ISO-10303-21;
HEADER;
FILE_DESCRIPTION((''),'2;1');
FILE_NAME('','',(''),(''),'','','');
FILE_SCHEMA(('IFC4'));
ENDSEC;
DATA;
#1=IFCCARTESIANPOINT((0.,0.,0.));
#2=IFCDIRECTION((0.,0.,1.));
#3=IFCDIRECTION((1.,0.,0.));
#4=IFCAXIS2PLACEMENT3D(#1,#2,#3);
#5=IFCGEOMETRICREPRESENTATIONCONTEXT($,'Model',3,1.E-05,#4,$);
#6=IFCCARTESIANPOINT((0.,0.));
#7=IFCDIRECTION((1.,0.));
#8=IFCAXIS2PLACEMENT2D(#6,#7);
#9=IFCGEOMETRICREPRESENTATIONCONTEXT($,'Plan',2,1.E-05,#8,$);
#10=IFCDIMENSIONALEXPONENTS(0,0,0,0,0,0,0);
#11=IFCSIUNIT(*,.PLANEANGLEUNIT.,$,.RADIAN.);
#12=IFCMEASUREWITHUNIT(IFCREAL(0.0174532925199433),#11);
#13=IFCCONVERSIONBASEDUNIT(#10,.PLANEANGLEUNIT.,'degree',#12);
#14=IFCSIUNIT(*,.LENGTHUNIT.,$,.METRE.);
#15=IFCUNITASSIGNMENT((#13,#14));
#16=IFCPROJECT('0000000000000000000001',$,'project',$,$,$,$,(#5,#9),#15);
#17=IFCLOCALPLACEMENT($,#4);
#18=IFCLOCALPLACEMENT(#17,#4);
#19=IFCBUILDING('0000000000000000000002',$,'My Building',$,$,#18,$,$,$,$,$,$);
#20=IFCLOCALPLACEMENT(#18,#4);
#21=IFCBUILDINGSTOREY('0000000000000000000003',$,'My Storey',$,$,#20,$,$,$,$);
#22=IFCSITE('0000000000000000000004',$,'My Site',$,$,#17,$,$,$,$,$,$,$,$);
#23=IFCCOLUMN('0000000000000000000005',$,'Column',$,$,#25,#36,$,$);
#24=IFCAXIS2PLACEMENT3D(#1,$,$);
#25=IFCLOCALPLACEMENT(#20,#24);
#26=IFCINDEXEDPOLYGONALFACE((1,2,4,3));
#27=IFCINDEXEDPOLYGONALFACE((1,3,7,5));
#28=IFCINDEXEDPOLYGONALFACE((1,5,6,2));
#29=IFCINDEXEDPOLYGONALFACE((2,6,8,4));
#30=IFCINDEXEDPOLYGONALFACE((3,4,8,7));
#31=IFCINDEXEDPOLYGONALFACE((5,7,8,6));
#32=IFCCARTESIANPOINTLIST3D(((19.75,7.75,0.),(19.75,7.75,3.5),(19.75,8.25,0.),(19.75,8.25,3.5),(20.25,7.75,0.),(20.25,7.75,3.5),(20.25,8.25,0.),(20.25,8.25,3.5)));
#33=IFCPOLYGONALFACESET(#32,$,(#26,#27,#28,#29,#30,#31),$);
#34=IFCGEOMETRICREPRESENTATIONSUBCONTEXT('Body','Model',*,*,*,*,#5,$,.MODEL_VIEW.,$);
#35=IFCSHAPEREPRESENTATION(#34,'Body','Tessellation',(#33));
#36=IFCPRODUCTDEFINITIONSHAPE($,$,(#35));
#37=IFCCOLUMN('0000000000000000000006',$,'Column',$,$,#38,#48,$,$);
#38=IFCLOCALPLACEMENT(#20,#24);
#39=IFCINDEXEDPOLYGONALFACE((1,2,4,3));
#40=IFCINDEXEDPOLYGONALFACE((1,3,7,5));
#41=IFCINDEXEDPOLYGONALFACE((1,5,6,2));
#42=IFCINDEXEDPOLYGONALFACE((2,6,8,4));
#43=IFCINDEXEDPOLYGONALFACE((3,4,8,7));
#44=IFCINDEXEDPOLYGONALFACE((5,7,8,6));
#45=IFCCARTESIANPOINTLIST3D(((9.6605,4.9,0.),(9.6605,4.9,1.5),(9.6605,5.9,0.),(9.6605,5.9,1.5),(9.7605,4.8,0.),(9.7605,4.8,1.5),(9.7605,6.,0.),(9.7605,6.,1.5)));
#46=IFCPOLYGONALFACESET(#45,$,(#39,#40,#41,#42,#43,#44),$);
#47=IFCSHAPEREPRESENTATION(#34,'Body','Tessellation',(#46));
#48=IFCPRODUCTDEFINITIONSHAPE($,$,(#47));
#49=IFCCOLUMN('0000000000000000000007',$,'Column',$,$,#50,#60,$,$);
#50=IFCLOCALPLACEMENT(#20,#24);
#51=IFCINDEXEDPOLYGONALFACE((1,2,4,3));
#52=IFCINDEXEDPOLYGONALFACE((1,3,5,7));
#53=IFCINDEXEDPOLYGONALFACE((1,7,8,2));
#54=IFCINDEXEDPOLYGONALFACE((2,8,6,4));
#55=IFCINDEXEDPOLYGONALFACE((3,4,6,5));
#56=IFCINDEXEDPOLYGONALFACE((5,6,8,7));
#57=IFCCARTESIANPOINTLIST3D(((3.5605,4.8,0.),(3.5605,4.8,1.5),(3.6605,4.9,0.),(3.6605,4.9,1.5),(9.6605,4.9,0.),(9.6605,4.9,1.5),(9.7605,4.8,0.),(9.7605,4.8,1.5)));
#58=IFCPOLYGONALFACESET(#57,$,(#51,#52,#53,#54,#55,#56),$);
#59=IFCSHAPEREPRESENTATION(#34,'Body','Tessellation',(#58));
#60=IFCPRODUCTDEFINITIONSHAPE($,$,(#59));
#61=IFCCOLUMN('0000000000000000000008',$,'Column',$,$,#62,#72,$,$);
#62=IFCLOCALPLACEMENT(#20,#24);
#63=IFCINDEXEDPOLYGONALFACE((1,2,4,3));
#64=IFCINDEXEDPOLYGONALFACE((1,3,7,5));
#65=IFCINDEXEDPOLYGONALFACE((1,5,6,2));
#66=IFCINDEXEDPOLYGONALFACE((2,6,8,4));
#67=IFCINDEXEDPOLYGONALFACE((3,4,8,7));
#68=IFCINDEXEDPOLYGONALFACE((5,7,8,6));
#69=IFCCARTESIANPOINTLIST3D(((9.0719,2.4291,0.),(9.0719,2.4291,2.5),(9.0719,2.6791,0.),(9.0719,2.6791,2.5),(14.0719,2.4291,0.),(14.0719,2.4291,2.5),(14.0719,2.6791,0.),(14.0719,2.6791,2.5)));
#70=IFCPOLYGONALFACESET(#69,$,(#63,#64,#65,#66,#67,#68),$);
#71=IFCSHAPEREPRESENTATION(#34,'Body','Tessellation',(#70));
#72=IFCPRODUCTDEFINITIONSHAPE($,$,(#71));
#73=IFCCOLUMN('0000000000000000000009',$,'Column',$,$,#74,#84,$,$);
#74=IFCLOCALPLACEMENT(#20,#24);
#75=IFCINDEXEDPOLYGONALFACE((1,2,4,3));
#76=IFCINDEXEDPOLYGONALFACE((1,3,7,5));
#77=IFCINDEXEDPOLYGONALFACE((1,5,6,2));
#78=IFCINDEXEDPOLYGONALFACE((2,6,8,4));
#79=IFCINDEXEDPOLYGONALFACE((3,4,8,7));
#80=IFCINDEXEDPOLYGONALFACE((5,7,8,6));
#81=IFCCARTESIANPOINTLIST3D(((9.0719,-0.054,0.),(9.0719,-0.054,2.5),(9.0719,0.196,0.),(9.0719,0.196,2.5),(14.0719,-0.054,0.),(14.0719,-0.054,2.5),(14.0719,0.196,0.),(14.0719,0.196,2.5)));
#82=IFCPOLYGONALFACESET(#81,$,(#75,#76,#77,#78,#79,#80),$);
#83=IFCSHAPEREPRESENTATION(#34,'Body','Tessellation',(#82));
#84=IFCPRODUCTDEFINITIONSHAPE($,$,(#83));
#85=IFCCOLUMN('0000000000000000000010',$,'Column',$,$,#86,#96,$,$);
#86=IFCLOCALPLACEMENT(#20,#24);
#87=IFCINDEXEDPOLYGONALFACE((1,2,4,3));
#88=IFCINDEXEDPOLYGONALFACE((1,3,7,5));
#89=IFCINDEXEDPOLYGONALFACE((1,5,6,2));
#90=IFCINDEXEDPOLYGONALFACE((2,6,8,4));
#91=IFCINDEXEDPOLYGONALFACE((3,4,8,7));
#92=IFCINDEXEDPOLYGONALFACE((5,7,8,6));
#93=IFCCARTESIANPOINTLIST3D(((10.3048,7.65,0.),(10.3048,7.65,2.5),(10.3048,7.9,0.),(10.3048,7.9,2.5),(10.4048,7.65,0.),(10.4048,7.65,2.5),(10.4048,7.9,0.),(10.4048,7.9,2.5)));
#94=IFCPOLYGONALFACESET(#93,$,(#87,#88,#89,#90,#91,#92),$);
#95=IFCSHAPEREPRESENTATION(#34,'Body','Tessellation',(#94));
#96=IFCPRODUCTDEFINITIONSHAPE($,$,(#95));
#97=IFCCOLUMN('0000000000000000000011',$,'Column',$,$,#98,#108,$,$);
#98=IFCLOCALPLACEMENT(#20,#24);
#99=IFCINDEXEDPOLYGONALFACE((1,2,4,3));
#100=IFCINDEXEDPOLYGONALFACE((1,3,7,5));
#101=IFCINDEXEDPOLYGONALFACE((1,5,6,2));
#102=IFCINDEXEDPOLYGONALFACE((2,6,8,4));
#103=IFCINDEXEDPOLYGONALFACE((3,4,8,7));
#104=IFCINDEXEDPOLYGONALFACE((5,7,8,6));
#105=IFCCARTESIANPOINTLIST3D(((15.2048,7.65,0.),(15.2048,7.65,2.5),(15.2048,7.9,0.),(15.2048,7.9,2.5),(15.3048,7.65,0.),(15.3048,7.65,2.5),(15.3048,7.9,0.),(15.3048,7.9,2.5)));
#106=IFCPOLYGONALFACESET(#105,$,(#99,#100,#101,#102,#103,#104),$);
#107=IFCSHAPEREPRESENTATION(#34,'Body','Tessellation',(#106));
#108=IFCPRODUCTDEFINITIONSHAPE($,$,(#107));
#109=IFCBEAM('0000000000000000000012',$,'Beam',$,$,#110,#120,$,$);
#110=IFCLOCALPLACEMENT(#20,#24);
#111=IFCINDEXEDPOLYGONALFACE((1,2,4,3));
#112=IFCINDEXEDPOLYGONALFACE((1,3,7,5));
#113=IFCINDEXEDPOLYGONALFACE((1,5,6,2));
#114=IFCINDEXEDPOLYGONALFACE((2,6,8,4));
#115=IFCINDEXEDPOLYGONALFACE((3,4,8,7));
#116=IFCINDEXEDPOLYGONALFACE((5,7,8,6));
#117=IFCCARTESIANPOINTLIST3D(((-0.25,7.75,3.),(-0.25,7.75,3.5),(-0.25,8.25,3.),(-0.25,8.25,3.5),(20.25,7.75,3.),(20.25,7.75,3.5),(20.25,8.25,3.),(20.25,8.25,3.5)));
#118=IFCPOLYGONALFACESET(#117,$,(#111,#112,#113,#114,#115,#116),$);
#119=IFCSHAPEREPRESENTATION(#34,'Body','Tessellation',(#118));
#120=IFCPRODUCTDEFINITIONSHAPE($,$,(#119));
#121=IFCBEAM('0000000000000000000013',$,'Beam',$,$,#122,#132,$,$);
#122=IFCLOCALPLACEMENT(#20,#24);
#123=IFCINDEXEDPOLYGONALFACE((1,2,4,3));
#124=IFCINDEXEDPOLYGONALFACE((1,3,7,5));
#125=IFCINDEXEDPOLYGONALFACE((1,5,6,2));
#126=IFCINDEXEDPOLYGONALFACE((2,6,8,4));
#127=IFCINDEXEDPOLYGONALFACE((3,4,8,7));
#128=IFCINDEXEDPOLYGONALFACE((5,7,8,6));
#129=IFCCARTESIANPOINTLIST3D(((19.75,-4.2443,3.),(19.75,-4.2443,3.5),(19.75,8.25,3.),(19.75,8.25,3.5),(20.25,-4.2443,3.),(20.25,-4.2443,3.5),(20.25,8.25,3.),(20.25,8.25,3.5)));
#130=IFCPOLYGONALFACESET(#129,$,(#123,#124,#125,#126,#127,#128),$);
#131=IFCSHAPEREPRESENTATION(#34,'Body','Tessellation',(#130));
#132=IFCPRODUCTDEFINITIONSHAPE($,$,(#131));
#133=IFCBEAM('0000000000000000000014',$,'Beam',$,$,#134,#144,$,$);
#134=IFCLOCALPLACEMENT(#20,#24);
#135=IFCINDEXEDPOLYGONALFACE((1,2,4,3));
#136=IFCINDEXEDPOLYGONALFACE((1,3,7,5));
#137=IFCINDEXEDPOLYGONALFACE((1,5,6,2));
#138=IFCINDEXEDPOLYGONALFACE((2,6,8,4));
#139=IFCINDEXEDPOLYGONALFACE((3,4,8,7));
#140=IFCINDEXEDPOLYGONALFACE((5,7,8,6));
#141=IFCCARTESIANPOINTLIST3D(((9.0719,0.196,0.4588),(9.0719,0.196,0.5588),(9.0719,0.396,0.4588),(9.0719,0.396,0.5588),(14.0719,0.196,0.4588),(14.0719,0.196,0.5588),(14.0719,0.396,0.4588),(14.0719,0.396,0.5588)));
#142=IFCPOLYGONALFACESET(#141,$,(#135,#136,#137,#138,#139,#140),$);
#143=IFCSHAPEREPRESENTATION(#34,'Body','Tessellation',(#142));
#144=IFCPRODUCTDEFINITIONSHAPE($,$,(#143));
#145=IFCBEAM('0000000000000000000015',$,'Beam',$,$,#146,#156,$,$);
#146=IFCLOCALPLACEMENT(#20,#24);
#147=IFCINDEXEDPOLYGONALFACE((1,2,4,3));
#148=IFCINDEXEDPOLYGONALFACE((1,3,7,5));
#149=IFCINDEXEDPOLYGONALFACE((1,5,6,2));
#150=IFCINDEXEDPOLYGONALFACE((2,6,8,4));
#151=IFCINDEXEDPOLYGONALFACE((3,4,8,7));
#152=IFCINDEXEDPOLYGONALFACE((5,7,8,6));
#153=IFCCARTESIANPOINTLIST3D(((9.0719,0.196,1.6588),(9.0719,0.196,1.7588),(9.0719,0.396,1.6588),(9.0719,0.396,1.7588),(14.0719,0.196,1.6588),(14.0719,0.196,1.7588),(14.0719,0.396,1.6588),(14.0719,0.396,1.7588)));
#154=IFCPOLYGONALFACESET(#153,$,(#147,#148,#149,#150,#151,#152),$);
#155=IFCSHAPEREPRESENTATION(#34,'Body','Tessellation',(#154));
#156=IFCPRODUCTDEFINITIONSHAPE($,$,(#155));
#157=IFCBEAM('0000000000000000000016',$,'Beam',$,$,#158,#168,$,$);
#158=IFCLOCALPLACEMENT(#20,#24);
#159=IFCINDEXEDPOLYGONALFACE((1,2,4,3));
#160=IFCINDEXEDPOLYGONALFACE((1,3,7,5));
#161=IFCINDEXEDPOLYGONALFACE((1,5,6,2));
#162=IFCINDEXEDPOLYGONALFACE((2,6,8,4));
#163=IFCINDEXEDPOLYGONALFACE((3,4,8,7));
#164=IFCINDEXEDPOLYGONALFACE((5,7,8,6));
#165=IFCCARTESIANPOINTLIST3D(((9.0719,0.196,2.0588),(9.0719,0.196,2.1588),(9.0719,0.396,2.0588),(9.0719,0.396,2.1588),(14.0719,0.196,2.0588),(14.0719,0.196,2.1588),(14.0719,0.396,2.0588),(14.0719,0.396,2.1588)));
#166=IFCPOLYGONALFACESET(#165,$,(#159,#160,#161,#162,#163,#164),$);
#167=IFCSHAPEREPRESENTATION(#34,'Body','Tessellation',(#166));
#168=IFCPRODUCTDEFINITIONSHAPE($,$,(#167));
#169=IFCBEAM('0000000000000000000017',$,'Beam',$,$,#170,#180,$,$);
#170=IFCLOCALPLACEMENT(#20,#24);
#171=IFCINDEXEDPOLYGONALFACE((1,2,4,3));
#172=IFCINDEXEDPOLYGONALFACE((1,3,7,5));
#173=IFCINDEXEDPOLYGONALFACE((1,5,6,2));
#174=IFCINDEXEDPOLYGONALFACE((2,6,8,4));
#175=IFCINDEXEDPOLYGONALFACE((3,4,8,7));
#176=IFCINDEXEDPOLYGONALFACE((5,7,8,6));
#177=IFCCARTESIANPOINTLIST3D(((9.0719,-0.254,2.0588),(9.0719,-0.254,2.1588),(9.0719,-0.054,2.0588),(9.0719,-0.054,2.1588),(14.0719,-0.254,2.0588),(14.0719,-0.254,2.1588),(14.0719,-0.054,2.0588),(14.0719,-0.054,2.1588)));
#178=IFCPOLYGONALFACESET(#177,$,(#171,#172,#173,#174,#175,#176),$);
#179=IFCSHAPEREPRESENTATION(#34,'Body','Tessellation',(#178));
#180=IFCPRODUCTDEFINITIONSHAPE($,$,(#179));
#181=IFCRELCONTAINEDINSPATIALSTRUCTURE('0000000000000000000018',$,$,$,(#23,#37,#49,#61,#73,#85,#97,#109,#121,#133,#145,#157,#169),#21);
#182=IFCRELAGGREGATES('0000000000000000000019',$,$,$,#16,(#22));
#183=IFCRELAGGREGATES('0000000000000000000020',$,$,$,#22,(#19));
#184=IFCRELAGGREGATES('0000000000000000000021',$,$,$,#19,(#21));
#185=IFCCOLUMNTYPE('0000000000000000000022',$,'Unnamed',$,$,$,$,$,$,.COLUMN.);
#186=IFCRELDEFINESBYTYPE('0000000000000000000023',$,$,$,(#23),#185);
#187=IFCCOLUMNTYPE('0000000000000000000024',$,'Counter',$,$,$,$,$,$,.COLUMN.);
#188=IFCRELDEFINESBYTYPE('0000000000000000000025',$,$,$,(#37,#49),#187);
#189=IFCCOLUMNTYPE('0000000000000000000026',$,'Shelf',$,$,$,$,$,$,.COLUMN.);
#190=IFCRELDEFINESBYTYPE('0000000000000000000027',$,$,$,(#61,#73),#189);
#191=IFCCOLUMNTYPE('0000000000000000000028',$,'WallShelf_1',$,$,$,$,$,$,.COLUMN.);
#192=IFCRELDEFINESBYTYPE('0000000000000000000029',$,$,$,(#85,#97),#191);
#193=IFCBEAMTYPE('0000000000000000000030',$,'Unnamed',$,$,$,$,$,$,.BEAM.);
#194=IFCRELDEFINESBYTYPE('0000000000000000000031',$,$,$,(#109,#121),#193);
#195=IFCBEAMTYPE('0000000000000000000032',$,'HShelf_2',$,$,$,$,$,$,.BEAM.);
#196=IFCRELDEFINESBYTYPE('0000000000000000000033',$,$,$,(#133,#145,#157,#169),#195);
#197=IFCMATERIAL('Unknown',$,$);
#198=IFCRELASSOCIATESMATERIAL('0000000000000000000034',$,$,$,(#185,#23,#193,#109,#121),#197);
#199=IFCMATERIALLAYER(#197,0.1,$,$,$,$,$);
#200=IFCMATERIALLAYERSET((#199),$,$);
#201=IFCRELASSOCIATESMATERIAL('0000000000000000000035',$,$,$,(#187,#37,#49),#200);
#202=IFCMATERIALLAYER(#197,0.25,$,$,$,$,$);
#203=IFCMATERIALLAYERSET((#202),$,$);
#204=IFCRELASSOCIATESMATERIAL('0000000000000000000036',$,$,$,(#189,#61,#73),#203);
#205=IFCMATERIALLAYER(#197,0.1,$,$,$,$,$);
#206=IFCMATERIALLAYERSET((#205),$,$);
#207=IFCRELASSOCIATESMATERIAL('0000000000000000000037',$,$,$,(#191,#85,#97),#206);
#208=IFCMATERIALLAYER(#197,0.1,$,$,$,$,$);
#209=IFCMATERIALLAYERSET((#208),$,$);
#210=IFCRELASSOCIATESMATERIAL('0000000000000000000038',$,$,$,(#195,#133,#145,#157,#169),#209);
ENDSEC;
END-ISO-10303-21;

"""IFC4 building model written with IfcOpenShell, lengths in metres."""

from ifc_helpers import new_model, entity, si_unit, converted_unit, frame, origin_with_axes, origin_2d_with_axis, place, context, subcontext, project, spatial, line, indexed_curve, rectangle, outline, extrude, material, layer, layer_set, layer_usage, material_profile, profile_set, profile_usage, type_object, element, save


model = new_model("IFC4")

# Units and contexts
model_context = context("Model", 3, precision=1e-05, world=origin_with_axes())
plan_context = context("Plan", 2, precision=1e-05, world=origin_2d_with_axis())
body_context_1 = subcontext(model_context, "Body", "Model", "MODEL_VIEW")
ifc_project = project(units=[converted_unit("PLANEANGLEUNIT", "degree", entity("IfcReal", 0.0174532925199433), si_unit("PLANEANGLEUNIT", "RADIAN"), dimensions=[0, 0, 0, 0, 0, 0, 0]), si_unit("LENGTHUNIT", "METRE")], contexts=[model_context, plan_context])

# Site, building, storey
site_placement = place(None, origin_with_axes())
site = spatial("IfcSite", under=ifc_project, at=site_placement, Name="My Site")
building_placement = place(site_placement, origin_with_axes())
building = spatial("IfcBuilding", under=site, at=building_placement, Name="My Building")
storey_placement = place(building_placement, origin_with_axes())
storey = spatial("IfcBuildingStorey", under=building, at=storey_placement, Name="My Storey")

# Columns
ifc_material = material(Name="Unknown")
ifc_material_profile_1 = material_profile(ifc_material, rectangle(XDim=0.5, YDim=0.5))
ifc_profile_set_1 = profile_set([ifc_material_profile_1])
ifc_profile_usage_1 = profile_usage(ifc_profile_set_1, cardinal=5)
column_type_1 = type_object("IfcColumnType", Name="Unnamed", PredefinedType="COLUMN", material=ifc_profile_set_1)
column_1_placement = place(storey_placement, frame((20.0, 8.0, 0.0), z_axis=(0.0, 0.0, 1.0), x_axis=(1.0, 0.0, 0.0)))
element("IfcColumn", 1, at=column_1_placement, inside=storey, type_object=column_type_1, material=ifc_profile_usage_1, Name="Column", context=body_context_1, shape_type="SweptSolid", body=[
    extrude(rectangle(XDim=0.5, YDim=0.5), origin_with_axes(), (0.0, 0.0, 1.0), 3.5),
])
ifc_layer_1 = layer(ifc_material, 0.1)
ifc_layer_set_1 = layer_set([ifc_layer_1])
ifc_layer_usage_1 = layer_usage(ifc_layer_set_1, "AXIS2", "POSITIVE", 0.0)
column_type_2 = type_object("IfcColumnType", Name="Counter", PredefinedType="COLUMN", material=ifc_layer_set_1)
column_2_placement = place(storey_placement, frame((9.6605, 5.9, 0.0), z_axis=(0.0, 0.0, 1.0), x_axis=(0.0, -1.0, 0.0)))
element("IfcColumn", 2, at=column_2_placement, inside=storey, type_object=column_type_2, material=ifc_layer_usage_1, Name="Column", context=body_context_1, shape_type="SweptSolid", body=[
    extrude(outline(indexed_curve([(0.0, 0.0), (-0.1, 0.1), (1.1, 0.1), (1.0, 0.0)], segments=[line(1, 2, 3, 4, 1)])), origin_with_axes(), (0.0, 0.0, 1.0), 1.5),
])
ifc_layer_usage_2 = layer_usage(ifc_layer_set_1, "AXIS2", "POSITIVE", 0.0)
column_3_placement = place(storey_placement, frame((9.6605, 4.9, 0.0), z_axis=(0.0, 0.0, 1.0), x_axis=(-1.0, 0.0, 0.0)))
element("IfcColumn", 3, at=column_3_placement, inside=storey, type_object=column_type_2, material=ifc_layer_usage_2, Name="Column", context=body_context_1, shape_type="SweptSolid", body=[
    extrude(outline(indexed_curve([(0.0, 0.0), (-0.1, 0.1), (6.1, 0.1), (6.0, 0.0)], segments=[line(1, 2, 3, 4, 1)])), origin_with_axes(), (0.0, 0.0, 1.0), 1.5),
])
ifc_layer_2 = layer(ifc_material, 0.25)
ifc_layer_set_2 = layer_set([ifc_layer_2])
ifc_layer_usage_3 = layer_usage(ifc_layer_set_2, "AXIS2", "POSITIVE", 0.0)
column_type_3 = type_object("IfcColumnType", Name="Shelf", PredefinedType="COLUMN", material=ifc_layer_set_2)
column_4_placement = place(storey_placement, frame((14.0719, 2.6791, 0.0), z_axis=(0.0, 0.0, 1.0), x_axis=(-1.0, 0.0, 0.0)))
element("IfcColumn", 4, at=column_4_placement, inside=storey, type_object=column_type_3, material=ifc_layer_usage_3, Name="Column", context=body_context_1, shape_type="SweptSolid", body=[
    extrude(outline(indexed_curve([(0.0, 0.0), (0.0, 0.25), (5.0, 0.25), (5.0, 0.0)], segments=[line(1, 2, 3, 4, 1)])), origin_with_axes(), (0.0, 0.0, 1.0), 2.5),
])
ifc_layer_usage_4 = layer_usage(ifc_layer_set_2, "AXIS2", "POSITIVE", 0.0)
column_5_placement = place(storey_placement, frame((14.0719, 0.196, 0.0), z_axis=(0.0, 0.0, 1.0), x_axis=(-1.0, 0.0, 0.0)))
element("IfcColumn", 5, at=column_5_placement, inside=storey, type_object=column_type_3, material=ifc_layer_usage_4, Name="Column", context=body_context_1, shape_type="SweptSolid", body=[
    extrude(outline(indexed_curve([(0.0, 0.0), (0.0, 0.25), (5.0, 0.25), (5.0, 0.0)], segments=[line(1, 2, 3, 4, 1)])), origin_with_axes(), (0.0, 0.0, 1.0), 2.5),
])
ifc_layer_3 = layer(ifc_material, 0.1)
ifc_layer_set_3 = layer_set([ifc_layer_3])
ifc_layer_usage_5 = layer_usage(ifc_layer_set_3, "AXIS2", "POSITIVE", 0.0)
column_type_4 = type_object("IfcColumnType", Name="WallShelf_1", PredefinedType="COLUMN", material=ifc_layer_set_3)
column_6_placement = place(storey_placement, frame((10.3048, 7.9, 0.0), z_axis=(0.0, 0.0, 1.0), x_axis=(0.0, -1.0, 0.0)))
element("IfcColumn", 6, at=column_6_placement, inside=storey, type_object=column_type_4, material=ifc_layer_usage_5, Name="Column", context=body_context_1, shape_type="SweptSolid", body=[
    extrude(outline(indexed_curve([(0.0, 0.0), (0.0, 0.1), (0.25, 0.1), (0.25, 0.0)], segments=[line(1, 2, 3, 4, 1)])), origin_with_axes(), (0.0, 0.0, 1.0), 2.5),
])
ifc_layer_usage_6 = layer_usage(ifc_layer_set_3, "AXIS2", "POSITIVE", 0.0)
column_7_placement = place(storey_placement, frame((15.2048, 7.9, 0.0), z_axis=(0.0, 0.0, 1.0), x_axis=(0.0, -1.0, 0.0)))
element("IfcColumn", 7, at=column_7_placement, inside=storey, type_object=column_type_4, material=ifc_layer_usage_6, Name="Column", context=body_context_1, shape_type="SweptSolid", body=[
    extrude(outline(indexed_curve([(0.0, 0.0), (0.0, 0.1), (0.25, 0.1), (0.25, 0.0)], segments=[line(1, 2, 3, 4, 1)])), origin_with_axes(), (0.0, 0.0, 1.0), 2.5),
])

# Beams
ifc_material_profile_2 = material_profile(ifc_material, rectangle(XDim=0.5, YDim=0.5))
ifc_profile_set_2 = profile_set([ifc_material_profile_2])
ifc_profile_usage_2 = profile_usage(ifc_profile_set_2, cardinal=5)
beam_type_1 = type_object("IfcBeamType", Name="Unnamed", PredefinedType="BEAM", material=ifc_profile_set_2)
beam_1_placement = place(storey_placement, frame((20.25, 8.0, 3.25), z_axis=(-1.0, 0.0, 0.0), x_axis=(0.0, -1.0, 0.0)))
element("IfcBeam", 8, at=beam_1_placement, inside=storey, type_object=beam_type_1, material=ifc_profile_usage_2, Name="Beam", context=body_context_1, shape_type="SweptSolid", body=[
    extrude(rectangle(XDim=0.5, YDim=0.5), origin_with_axes(), (0.0, 0.0, 1.0), 20.5),
])
ifc_profile_usage_3 = profile_usage(ifc_profile_set_2, cardinal=2)
beam_2_placement = place(storey_placement, frame((20.0, 8.25, 3.0), z_axis=(0.0, -1.0, 0.0), x_axis=(1.0, 0.0, 0.0)))
element("IfcBeam", 9, at=beam_2_placement, inside=storey, type_object=beam_type_1, material=ifc_profile_usage_3, Name="Beam", context=body_context_1, shape_type="SweptSolid", body=[
    extrude(rectangle(XDim=0.5, YDim=0.5), frame((0.0, 0.25, 0.0), z_axis=(0.0, 0.0, 1.0), x_axis=(1.0, 0.0, 0.0)), (0.0, 0.0, 1.0), 12.4943),
])
ifc_layer_4 = layer(ifc_material, 0.1)
ifc_layer_set_4 = layer_set([ifc_layer_4])
ifc_layer_usage_7 = layer_usage(ifc_layer_set_4, "AXIS3", "POSITIVE", -0.1)
beam_type_2 = type_object("IfcBeamType", Name="HShelf_2", PredefinedType="BEAM", material=ifc_layer_set_4)
beam_3_placement = place(storey_placement, frame((9.0719, 0.396, 0.5588), z_axis=(0.0, 0.0, 1.0), x_axis=(1.0, 0.0, 0.0)))
element("IfcBeam", 10, at=beam_3_placement, inside=storey, type_object=beam_type_2, material=ifc_layer_usage_7, Name="Beam", context=body_context_1, shape_type="SweptSolid", body=[
    extrude(outline(indexed_curve([(0.0, 0.0), (0.0, -0.2), (5.0, -0.2), (5.0, 0.0), (0.0, 0.0)])), frame((0.0, 0.0, -0.1), z_axis=(0.0, 0.0, 1.0), x_axis=(1.0, 0.0, 0.0)), (0.0, 0.0, 1.0), 0.1),
])
ifc_layer_usage_8 = layer_usage(ifc_layer_set_4, "AXIS3", "POSITIVE", -0.1)
beam_4_placement = place(storey_placement, frame((9.0719, 0.396, 1.7588), z_axis=(0.0, 0.0, 1.0), x_axis=(1.0, 0.0, 0.0)))
element("IfcBeam", 11, at=beam_4_placement, inside=storey, type_object=beam_type_2, material=ifc_layer_usage_8, Name="Beam", context=body_context_1, shape_type="SweptSolid", body=[
    extrude(outline(indexed_curve([(0.0, 0.0), (0.0, -0.2), (5.0, -0.2), (5.0, 0.0), (0.0, 0.0)])), frame((0.0, 0.0, -0.1), z_axis=(0.0, 0.0, 1.0), x_axis=(1.0, 0.0, 0.0)), (0.0, 0.0, 1.0), 0.1),
])
ifc_layer_usage_9 = layer_usage(ifc_layer_set_4, "AXIS3", "POSITIVE", -0.1)
beam_5_placement = place(storey_placement, frame((9.0719, 0.396, 2.1588), z_axis=(0.0, 0.0, 1.0), x_axis=(1.0, 0.0, 0.0)))
element("IfcBeam", 12, at=beam_5_placement, inside=storey, type_object=beam_type_2, material=ifc_layer_usage_9, Name="Beam", context=body_context_1, shape_type="SweptSolid", body=[
    extrude(outline(indexed_curve([(0.0, 0.0), (0.0, -0.2), (5.0, -0.2), (5.0, 0.0), (0.0, 0.0)])), frame((0.0, 0.0, -0.1), z_axis=(0.0, 0.0, 1.0), x_axis=(1.0, 0.0, 0.0)), (0.0, 0.0, 1.0), 0.1),
])
ifc_layer_usage_10 = layer_usage(ifc_layer_set_4, "AXIS3", "POSITIVE", -0.1)
beam_6_placement = place(storey_placement, frame((9.0719, -0.054, 2.1588), z_axis=(0.0, 0.0, 1.0), x_axis=(1.0, 0.0, 0.0)))
element("IfcBeam", 13, at=beam_6_placement, inside=storey, type_object=beam_type_2, material=ifc_layer_usage_10, Name="Beam", context=body_context_1, shape_type="SweptSolid", body=[
    extrude(outline(indexed_curve([(0.0, 0.0), (0.0, -0.2), (5.0, -0.2), (5.0, 0.0), (0.0, 0.0)])), frame((0.0, 0.0, -0.1), z_axis=(0.0, 0.0, 1.0), x_axis=(1.0, 0.0, 0.0)), (0.0, 0.0, 1.0), 0.1),
])

save(model, "model.ifc")
